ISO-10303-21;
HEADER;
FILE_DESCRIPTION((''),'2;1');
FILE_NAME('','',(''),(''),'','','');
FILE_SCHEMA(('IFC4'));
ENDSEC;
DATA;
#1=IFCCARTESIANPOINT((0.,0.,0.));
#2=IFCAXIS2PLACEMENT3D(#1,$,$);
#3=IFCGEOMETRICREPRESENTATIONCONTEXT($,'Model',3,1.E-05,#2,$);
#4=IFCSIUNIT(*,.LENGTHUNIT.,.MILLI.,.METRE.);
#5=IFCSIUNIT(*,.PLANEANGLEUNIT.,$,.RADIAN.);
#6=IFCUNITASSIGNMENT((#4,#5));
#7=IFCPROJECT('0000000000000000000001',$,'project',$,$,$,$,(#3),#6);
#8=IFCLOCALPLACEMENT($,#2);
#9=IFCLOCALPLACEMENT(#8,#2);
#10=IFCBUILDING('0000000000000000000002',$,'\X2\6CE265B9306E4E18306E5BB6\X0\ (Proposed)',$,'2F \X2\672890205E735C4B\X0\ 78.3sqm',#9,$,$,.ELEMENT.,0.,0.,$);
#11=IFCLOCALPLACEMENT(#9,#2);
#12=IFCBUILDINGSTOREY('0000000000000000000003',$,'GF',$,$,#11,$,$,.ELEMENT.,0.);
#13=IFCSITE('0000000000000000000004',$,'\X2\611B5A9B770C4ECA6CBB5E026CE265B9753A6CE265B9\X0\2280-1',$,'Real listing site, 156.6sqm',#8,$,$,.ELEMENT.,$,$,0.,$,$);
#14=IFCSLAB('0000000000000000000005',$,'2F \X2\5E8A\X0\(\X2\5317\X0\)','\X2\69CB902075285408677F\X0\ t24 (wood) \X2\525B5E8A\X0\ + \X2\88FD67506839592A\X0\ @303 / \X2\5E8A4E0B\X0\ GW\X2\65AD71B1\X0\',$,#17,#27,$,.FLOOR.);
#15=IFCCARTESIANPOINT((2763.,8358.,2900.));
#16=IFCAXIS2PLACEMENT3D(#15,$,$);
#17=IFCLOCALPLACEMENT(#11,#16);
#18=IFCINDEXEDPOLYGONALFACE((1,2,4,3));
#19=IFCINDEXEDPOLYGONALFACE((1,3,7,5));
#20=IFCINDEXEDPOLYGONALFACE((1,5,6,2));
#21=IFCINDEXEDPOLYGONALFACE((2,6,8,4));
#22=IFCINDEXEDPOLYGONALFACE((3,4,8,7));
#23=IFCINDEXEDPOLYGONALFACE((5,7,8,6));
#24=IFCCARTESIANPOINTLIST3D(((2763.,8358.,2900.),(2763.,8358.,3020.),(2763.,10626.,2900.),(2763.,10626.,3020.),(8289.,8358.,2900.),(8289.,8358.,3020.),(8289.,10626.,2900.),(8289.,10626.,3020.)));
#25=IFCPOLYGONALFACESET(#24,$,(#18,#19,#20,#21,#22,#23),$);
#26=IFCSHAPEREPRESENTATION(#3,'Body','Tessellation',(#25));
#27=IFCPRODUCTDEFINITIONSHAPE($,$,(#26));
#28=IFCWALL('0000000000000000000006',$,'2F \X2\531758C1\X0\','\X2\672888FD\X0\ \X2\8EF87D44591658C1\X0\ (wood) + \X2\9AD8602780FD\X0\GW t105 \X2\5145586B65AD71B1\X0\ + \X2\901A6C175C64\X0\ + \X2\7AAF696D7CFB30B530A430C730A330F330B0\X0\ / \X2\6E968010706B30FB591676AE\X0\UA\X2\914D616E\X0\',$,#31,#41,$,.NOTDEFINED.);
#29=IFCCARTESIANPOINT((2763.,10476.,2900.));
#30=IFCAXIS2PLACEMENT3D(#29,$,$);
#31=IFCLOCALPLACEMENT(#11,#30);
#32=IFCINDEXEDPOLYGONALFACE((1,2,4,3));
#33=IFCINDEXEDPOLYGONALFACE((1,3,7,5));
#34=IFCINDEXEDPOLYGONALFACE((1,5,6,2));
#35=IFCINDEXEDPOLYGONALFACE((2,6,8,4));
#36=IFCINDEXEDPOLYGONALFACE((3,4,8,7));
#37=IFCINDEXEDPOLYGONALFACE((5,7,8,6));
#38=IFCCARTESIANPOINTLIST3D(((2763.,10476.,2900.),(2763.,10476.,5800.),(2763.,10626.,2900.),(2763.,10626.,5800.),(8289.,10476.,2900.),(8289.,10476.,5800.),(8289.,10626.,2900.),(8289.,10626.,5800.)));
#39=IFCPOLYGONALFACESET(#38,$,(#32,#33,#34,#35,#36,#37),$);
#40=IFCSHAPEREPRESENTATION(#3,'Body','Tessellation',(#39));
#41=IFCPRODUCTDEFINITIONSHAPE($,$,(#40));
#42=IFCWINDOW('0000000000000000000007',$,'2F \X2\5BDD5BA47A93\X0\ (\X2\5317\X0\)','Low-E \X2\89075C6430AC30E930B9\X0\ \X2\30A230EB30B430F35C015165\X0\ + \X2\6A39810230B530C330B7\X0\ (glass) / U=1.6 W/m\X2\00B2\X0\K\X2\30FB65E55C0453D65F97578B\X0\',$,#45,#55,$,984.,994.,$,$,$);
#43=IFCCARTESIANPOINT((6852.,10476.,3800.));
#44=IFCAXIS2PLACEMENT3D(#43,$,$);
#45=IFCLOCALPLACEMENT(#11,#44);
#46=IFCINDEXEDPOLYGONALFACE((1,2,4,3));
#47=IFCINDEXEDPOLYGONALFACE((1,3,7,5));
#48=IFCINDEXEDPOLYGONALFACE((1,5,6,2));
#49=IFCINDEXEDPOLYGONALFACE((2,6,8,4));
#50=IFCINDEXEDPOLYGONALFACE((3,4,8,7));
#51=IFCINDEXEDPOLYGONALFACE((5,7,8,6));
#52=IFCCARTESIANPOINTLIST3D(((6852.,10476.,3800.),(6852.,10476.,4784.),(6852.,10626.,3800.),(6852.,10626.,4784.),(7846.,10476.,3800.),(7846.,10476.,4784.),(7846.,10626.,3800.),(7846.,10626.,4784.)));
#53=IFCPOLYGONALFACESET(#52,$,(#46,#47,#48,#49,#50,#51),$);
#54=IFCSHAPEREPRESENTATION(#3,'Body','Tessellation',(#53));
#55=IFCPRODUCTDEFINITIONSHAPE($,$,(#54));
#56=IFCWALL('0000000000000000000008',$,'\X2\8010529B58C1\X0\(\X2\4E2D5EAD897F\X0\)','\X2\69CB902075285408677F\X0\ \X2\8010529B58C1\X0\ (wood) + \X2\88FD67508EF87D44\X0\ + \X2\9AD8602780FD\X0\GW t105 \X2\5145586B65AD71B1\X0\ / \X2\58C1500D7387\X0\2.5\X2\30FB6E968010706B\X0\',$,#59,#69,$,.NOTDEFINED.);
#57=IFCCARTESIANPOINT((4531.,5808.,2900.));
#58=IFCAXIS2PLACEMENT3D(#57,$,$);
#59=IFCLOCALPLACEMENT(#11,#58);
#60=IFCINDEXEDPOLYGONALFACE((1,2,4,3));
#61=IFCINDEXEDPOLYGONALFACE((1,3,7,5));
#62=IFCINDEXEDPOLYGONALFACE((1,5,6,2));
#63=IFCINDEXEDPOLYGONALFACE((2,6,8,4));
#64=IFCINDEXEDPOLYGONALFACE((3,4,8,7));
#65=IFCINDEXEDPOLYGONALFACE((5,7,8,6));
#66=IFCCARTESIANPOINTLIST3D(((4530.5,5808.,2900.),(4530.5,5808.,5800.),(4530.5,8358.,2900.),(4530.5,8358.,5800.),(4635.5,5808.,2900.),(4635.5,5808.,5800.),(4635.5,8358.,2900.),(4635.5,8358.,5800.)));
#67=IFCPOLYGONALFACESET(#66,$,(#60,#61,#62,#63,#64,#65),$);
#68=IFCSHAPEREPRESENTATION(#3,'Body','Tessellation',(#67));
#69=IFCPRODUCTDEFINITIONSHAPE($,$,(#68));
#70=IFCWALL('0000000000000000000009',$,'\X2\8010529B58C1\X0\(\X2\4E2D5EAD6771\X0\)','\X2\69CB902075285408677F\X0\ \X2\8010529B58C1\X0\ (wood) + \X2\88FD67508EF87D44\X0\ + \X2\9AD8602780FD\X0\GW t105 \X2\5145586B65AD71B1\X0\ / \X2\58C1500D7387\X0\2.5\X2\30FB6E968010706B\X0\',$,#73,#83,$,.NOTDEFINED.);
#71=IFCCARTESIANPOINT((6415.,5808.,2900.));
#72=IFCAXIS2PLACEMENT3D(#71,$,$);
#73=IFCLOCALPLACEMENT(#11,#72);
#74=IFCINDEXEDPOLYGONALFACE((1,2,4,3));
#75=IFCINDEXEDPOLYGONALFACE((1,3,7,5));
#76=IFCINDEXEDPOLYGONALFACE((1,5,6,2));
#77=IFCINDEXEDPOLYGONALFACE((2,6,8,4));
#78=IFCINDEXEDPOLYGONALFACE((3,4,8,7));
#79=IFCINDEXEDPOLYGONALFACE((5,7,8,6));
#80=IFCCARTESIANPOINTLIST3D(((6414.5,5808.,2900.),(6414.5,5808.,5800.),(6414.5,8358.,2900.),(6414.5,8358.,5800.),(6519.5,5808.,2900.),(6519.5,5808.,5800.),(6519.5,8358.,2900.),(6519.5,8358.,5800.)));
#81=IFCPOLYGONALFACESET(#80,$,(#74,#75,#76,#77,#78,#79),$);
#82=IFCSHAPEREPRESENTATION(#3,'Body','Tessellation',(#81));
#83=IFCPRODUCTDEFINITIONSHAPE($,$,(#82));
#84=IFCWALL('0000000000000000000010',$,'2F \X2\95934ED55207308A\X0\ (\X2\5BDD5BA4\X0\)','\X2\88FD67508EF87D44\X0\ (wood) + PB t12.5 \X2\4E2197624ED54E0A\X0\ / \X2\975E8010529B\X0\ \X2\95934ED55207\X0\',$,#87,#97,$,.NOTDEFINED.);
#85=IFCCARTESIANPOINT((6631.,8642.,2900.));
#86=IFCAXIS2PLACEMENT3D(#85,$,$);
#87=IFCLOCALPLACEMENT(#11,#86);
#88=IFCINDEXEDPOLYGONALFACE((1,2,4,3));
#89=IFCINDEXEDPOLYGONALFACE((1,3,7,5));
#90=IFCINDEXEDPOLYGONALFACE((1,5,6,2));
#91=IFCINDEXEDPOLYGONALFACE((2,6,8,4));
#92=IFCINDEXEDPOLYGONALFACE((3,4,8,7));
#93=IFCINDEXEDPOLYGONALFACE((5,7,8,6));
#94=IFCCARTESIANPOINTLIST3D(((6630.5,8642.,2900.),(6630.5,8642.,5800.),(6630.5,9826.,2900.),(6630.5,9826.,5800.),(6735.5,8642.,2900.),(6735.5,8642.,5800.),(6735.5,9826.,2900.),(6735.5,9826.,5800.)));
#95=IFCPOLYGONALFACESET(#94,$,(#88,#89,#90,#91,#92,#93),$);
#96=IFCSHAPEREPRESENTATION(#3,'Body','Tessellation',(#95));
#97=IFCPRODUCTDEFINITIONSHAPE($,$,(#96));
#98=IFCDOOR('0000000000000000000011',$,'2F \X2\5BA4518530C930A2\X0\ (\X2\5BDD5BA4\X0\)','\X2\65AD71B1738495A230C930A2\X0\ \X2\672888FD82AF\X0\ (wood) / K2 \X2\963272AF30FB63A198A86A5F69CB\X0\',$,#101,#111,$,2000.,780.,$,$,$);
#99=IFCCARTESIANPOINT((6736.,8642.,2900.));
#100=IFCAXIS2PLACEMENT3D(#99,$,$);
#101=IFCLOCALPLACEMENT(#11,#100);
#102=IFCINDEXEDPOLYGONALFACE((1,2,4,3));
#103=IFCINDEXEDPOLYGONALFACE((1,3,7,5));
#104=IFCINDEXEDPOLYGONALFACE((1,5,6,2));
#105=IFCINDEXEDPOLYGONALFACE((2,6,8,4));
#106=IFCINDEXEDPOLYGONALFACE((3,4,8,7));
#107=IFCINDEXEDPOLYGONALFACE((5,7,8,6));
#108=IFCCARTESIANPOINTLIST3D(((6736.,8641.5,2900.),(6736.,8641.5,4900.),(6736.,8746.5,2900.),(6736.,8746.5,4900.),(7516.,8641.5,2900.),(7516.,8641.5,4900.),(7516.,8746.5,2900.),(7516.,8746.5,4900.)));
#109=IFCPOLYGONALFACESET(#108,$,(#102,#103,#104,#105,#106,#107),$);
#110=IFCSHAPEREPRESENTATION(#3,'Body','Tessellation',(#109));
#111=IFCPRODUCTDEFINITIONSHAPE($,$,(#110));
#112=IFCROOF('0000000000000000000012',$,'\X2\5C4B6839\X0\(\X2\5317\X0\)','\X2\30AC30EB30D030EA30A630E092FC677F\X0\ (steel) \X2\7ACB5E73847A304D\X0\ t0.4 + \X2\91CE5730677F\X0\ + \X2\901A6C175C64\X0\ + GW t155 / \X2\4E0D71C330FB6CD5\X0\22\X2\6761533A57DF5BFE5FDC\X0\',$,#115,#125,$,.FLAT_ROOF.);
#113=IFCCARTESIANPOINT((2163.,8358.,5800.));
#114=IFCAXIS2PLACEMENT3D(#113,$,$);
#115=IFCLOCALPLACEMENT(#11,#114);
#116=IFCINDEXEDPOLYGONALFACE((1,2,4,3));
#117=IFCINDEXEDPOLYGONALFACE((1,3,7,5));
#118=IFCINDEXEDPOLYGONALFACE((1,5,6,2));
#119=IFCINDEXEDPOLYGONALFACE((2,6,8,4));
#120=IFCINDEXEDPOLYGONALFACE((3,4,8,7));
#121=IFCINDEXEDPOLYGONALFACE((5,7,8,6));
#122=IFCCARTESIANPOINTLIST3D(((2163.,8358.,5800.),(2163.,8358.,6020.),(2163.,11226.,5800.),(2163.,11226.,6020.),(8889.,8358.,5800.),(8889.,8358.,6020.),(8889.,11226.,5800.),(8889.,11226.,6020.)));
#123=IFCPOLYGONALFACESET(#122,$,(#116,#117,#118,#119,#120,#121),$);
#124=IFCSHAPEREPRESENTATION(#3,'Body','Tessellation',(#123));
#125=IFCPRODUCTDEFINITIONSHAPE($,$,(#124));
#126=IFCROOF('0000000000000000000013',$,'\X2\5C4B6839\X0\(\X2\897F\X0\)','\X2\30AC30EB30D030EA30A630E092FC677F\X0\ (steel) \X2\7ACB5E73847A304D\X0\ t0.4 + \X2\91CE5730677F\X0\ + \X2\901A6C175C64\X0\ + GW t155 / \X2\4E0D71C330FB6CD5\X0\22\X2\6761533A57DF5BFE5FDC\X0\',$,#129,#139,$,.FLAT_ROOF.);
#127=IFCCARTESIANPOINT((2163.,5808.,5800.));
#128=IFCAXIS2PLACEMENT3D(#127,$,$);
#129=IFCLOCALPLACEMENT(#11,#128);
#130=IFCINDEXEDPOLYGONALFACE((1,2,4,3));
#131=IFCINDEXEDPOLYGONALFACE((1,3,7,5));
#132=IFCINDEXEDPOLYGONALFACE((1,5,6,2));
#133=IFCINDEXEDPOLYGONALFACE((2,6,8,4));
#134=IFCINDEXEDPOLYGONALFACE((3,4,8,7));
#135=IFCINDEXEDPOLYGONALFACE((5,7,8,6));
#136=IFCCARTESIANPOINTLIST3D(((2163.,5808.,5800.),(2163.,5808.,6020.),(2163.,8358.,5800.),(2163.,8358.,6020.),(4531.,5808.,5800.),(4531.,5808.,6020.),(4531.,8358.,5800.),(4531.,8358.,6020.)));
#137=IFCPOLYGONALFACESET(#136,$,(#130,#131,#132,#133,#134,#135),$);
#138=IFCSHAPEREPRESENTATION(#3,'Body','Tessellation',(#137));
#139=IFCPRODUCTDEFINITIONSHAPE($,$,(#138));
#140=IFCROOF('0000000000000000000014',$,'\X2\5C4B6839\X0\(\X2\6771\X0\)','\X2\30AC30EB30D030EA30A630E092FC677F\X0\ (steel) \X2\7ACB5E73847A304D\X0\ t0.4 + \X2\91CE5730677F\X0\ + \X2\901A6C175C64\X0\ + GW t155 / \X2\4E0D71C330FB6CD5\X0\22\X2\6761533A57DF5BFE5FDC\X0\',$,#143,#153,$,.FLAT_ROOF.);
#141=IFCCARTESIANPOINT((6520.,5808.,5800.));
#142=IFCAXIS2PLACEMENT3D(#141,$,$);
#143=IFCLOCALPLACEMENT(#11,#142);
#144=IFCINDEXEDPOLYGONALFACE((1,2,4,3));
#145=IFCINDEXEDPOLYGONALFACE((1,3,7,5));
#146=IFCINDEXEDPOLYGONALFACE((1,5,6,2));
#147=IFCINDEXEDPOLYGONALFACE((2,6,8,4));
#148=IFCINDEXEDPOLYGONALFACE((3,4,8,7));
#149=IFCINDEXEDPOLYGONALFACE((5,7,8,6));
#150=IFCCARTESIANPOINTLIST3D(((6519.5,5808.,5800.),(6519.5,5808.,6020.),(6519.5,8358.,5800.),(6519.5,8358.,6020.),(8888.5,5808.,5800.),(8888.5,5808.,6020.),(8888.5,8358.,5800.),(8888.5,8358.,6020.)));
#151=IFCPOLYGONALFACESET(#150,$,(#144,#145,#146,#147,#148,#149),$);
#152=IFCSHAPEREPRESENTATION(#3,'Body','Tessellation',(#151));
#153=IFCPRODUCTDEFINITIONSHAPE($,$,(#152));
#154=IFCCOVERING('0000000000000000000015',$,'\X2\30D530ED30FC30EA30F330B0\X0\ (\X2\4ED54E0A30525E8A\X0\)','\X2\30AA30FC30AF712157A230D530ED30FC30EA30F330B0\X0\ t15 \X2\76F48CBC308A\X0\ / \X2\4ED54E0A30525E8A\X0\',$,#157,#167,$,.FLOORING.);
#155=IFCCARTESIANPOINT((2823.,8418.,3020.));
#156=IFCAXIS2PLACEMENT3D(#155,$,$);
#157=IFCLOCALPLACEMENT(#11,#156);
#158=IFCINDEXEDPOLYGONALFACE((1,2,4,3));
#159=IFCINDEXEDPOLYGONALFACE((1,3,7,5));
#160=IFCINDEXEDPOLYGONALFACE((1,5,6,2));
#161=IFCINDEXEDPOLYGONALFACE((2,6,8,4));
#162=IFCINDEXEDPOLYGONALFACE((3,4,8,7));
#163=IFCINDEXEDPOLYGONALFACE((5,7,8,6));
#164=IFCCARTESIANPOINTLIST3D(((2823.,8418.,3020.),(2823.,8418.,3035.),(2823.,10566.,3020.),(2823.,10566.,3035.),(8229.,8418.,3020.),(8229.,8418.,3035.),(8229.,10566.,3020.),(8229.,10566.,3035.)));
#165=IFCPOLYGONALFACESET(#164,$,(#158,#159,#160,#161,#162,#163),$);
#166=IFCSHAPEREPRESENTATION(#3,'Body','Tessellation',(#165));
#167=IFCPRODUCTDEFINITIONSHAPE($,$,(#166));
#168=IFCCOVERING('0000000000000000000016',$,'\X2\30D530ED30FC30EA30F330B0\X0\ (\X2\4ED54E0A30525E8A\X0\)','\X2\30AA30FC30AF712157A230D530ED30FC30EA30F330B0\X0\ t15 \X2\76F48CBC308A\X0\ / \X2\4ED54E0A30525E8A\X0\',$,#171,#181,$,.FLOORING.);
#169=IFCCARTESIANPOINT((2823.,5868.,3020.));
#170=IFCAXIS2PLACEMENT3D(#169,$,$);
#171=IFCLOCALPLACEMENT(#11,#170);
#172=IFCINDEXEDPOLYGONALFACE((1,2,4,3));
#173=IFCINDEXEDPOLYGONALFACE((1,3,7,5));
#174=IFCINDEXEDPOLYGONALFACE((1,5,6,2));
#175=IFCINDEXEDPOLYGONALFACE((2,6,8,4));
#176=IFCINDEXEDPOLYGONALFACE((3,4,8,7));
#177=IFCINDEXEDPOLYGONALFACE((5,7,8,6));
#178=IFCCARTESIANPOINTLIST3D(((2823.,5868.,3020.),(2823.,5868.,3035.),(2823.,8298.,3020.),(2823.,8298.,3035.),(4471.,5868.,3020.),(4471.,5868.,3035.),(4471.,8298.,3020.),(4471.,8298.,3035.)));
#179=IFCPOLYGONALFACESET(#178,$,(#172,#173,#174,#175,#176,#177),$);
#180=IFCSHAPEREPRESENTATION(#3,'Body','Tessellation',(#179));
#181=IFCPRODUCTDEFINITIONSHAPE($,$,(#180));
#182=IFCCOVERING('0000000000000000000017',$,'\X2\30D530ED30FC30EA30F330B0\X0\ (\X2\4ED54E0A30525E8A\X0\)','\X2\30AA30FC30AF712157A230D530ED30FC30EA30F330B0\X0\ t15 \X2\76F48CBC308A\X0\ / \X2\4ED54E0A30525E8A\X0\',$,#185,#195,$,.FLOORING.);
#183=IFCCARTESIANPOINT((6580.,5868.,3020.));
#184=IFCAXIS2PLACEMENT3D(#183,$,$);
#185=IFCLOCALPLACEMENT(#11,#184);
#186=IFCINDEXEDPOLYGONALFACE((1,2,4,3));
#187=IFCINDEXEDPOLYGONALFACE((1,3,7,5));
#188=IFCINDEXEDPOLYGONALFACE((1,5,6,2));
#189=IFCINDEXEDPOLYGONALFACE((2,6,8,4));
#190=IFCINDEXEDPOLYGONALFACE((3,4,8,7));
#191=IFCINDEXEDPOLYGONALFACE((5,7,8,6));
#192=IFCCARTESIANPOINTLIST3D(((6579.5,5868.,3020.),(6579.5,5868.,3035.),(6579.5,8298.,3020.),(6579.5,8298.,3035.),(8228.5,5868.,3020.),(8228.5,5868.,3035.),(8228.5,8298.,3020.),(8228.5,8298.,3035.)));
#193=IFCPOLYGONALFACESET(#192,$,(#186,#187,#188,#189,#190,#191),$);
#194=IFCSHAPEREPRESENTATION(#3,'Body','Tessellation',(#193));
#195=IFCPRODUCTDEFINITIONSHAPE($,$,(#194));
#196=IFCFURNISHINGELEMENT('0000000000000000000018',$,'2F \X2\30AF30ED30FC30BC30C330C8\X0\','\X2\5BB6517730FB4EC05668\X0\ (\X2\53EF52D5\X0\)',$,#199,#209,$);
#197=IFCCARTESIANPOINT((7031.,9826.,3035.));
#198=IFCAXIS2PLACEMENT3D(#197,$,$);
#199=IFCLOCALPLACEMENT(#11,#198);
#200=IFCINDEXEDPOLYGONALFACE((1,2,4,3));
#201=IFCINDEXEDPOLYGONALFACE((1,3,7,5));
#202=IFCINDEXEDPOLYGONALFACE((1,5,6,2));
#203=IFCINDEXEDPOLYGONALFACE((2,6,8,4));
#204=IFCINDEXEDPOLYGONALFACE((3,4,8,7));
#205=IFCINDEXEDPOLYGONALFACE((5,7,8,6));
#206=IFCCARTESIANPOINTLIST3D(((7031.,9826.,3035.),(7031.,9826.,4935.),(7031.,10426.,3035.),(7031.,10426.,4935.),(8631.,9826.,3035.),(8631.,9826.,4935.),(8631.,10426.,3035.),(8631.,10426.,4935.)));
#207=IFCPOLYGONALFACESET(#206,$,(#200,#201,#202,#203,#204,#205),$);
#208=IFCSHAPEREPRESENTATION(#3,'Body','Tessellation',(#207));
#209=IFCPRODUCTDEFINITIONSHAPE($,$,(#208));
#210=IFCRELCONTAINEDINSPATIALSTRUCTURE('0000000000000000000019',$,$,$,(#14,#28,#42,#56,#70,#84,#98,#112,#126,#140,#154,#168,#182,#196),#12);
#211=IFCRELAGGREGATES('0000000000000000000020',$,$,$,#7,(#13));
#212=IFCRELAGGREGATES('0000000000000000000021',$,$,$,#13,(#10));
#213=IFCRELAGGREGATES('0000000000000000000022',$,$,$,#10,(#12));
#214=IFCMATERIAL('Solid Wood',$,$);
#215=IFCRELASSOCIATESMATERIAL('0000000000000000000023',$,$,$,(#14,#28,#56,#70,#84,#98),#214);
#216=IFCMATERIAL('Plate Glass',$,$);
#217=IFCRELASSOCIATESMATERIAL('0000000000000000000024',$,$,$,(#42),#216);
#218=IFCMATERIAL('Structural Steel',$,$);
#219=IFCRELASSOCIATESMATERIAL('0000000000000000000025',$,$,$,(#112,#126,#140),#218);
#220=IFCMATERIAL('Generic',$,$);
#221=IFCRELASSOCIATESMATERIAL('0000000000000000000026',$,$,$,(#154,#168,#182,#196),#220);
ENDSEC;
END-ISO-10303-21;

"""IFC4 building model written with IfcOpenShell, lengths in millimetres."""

from ifc_helpers import new_model, si_unit, frame, frame_2d, origin, place, context, project, spatial, rectangle, extrude, material, element, fill, save


model = new_model("IFC4")

# Units and contexts
model_context = context("Model", 3, precision=1e-05, world=origin())
ifc_project = project(units=[si_unit("LENGTHUNIT", "METRE", prefix="MILLI"), si_unit("PLANEANGLEUNIT", "RADIAN")], contexts=[model_context])

# Site, building, storey
site_placement = place(None, origin())
site = spatial("IfcSite", under=ifc_project, at=site_placement, Name="愛媛県今治市波方町波方2280-1", ObjectType="Real listing site, 156.6sqm", CompositionType="ELEMENT", RefElevation=0.0)
building_placement = place(site_placement, origin())
building = spatial("IfcBuilding", under=site, at=building_placement, Name="波方の丘の家 (Proposed)", ObjectType="2F 木造平屋 78.3sqm", CompositionType="ELEMENT", ElevationOfRefHeight=0.0, ElevationOfTerrain=0.0)
storey_placement = place(building_placement, origin())
storey = spatial("IfcBuildingStorey", under=building, at=storey_placement, Name="GF", CompositionType="ELEMENT", Elevation=0.0)

# Slab
ifc_material_1 = material(Name="Solid Wood")
slab_placement = place(storey_placement, frame((2763.0, 8358.0, 2900.0)))
element("IfcSlab", 1, at=slab_placement, inside=storey, material=ifc_material_1, Name="2F 床(北)", Description="構造用合板 t24 (wood) 剛床 + 製材根太 @303 / 床下 GW断熱", PredefinedType="FLOOR", context=model_context, shape_type="SweptSolid", body=[
    extrude(rectangle(XDim=5526.0, YDim=2268.0, at=frame_2d((2763.0, 1134.0))), frame((2763.0, 8358.0, 2900.0)), (0.0, 0.0, 1.0), 120.0),
])

# Wall, opening, window
wall_1_placement = place(storey_placement, frame((2763.0, 10476.0, 2900.0)))
wall_1 = element("IfcWall", 2, at=wall_1_placement, inside=storey, material=ifc_material_1, Name="2F 北壁", Description="木製 軸組外壁 (wood) + 高性能GW t105 充填断熱 + 通気層 + 窯業系サイディング / 準耐火・外皮UA配慮", PredefinedType="NOTDEFINED", context=model_context, shape_type="SweptSolid", body=[
    extrude(rectangle(XDim=5526.0, YDim=150.0, at=frame_2d((2763.0, 75.0))), frame((2763.0, 10476.0, 2900.0)), (0.0, 0.0, 1.0), 2900.0),
])
opening_1_placement = place(storey_placement, frame((6852.0, 10476.0, 3800.0)))
opening_1 = element("IfcOpeningElement", 3, at=opening_1_placement, cuts=wall_1, PredefinedType="NOTDEFINED", context=model_context, shape_type="SweptSolid", body=[
    extrude(rectangle(XDim=994.0, YDim=150.0, at=frame_2d((497.0, 75.0))), frame((6852.0, 10476.0, 3800.0)), (0.0, 0.0, 1.0), 984.0),
])
ifc_material_2 = material(Name="Plate Glass")
window_1_placement = place(storey_placement, frame((6852.0, 10476.0, 3800.0)))
window_1 = element("IfcWindow", 4, at=window_1_placement, inside=storey, material=ifc_material_2, Name="2F 寝室窓 (北)", Description="Low-E 複層ガラス アルゴン封入 + 樹脂サッシ (glass) / U=1.6 W/m²K・日射取得型", OverallHeight=984.0, OverallWidth=994.0, context=model_context, shape_type="SweptSolid", body=[
    extrude(rectangle(XDim=994.0, YDim=150.0, at=frame_2d((497.0, 75.0))), frame((6852.0, 10476.0, 3800.0)), (0.0, 0.0, 1.0), 984.0),
])
fill(opening_1, window_1)

# Walls
wall_2_placement = place(storey_placement, frame((4531.0, 5808.0, 2900.0)))
element("IfcWall", 5, at=wall_2_placement, inside=storey, material=ifc_material_1, Name="耐力壁(中庭西)", Description="構造用合板 耐力壁 (wood) + 製材軸組 + 高性能GW t105 充填断熱 / 壁倍率2.5・準耐火", PredefinedType="NOTDEFINED", context=model_context, shape_type="SweptSolid", body=[
    extrude(rectangle(XDim=105.0, YDim=2550.0, at=frame_2d((52.0, 1275.0))), frame((4531.0, 5808.0, 2900.0)), (0.0, 0.0, 1.0), 2900.0),
])
wall_3_placement = place(storey_placement, frame((6415.0, 5808.0, 2900.0)))
element("IfcWall", 6, at=wall_3_placement, inside=storey, material=ifc_material_1, Name="耐力壁(中庭東)", Description="構造用合板 耐力壁 (wood) + 製材軸組 + 高性能GW t105 充填断熱 / 壁倍率2.5・準耐火", PredefinedType="NOTDEFINED", context=model_context, shape_type="SweptSolid", body=[
    extrude(rectangle(XDim=105.0, YDim=2550.0, at=frame_2d((52.0, 1275.0))), frame((6415.0, 5808.0, 2900.0)), (0.0, 0.0, 1.0), 2900.0),
])
wall_4_placement = place(storey_placement, frame((6631.0, 8642.0, 2900.0)))
element("IfcWall", 7, at=wall_4_placement, inside=storey, material=ifc_material_1, Name="2F 間仕切り (寝室)", Description="製材軸組 (wood) + PB t12.5 両面仕上 / 非耐力 間仕切", PredefinedType="NOTDEFINED", context=model_context, shape_type="SweptSolid", body=[
    extrude(rectangle(XDim=105.0, YDim=1184.0, at=frame_2d((52.0, 592.0))), frame((6631.0, 8642.0, 2900.0)), (0.0, 0.0, 1.0), 2900.0),
])

# Door
door_placement = place(storey_placement, frame((6736.0, 8642.0, 2900.0)))
element("IfcDoor", 8, at=door_placement, inside=storey, material=ifc_material_1, Name="2F 室内ドア (寝室)", Description="断熱玄関ドア 木製芯 (wood) / K2 防犯・採風機構", OverallHeight=2000.0, OverallWidth=780.0, context=model_context, shape_type="SweptSolid", body=[
    extrude(rectangle(XDim=780.0, YDim=105.0, at=frame_2d((390.0, 52.0))), frame((6736.0, 8642.0, 2900.0)), (0.0, 0.0, 1.0), 2000.0),
])

# Roofs
ifc_material_3 = material(Name="Structural Steel")
for number, where, name in (
    (9, (2163.0, 8358.0, 5800.0), "屋根(北)"),
):
    element("IfcRoof", number, at=place(storey_placement, frame(where)), inside=storey, material=ifc_material_3, Name=name, Description="ガルバリウム鋼板 (steel) 立平葺き t0.4 + 野地板 + 通気層 + GW t155 / 不燃・法22条区域対応", PredefinedType="FLAT_ROOF", context=model_context, shape_type="SweptSolid", body=[
        extrude(rectangle(XDim=6726.0, YDim=2868.0, at=frame_2d((3363.0, 1434.0))), frame((2163.0, 8358.0, 5800.0)), (0.0, 0.0, 1.0), 220.0),
    ])
roof_1_placement = place(storey_placement, frame((2163.0, 5808.0, 5800.0)))
element("IfcRoof", 10, at=roof_1_placement, inside=storey, material=ifc_material_3, Name="屋根(西)", Description="ガルバリウム鋼板 (steel) 立平葺き t0.4 + 野地板 + 通気層 + GW t155 / 不燃・法22条区域対応", PredefinedType="FLAT_ROOF", context=model_context, shape_type="SweptSolid", body=[
    extrude(rectangle(XDim=2368.0, YDim=2550.0, at=frame_2d((1184.0, 1275.0))), frame((2163.0, 5808.0, 5800.0)), (0.0, 0.0, 1.0), 220.0),
])
roof_2_placement = place(storey_placement, frame((6520.0, 5808.0, 5800.0)))
element("IfcRoof", 11, at=roof_2_placement, inside=storey, material=ifc_material_3, Name="屋根(東)", Description="ガルバリウム鋼板 (steel) 立平葺き t0.4 + 野地板 + 通気層 + GW t155 / 不燃・法22条区域対応", PredefinedType="FLAT_ROOF", context=model_context, shape_type="SweptSolid", body=[
    extrude(rectangle(XDim=2369.0, YDim=2550.0, at=frame_2d((1184.0, 1275.0))), frame((6520.0, 5808.0, 5800.0)), (0.0, 0.0, 1.0), 220.0),
])

# Coverings
ifc_material_4 = material(Name="Generic")
covering_1_placement = place(storey_placement, frame((2823.0, 8418.0, 3020.0)))
element("IfcCovering", 12, at=covering_1_placement, inside=storey, material=ifc_material_4, Name="フローリング (仕上げ床)", Description="オーク無垢フローリング t15 直貼り / 仕上げ床", PredefinedType="FLOORING", context=model_context, shape_type="SweptSolid", body=[
    extrude(rectangle(XDim=5406.0, YDim=2148.0, at=frame_2d((2703.0, 1074.0))), frame((2823.0, 8418.0, 3020.0)), (0.0, 0.0, 1.0), 15.0),
])
covering_2_placement = place(storey_placement, frame((2823.0, 5868.0, 3020.0)))
element("IfcCovering", 13, at=covering_2_placement, inside=storey, material=ifc_material_4, Name="フローリング (仕上げ床)", Description="オーク無垢フローリング t15 直貼り / 仕上げ床", PredefinedType="FLOORING", context=model_context, shape_type="SweptSolid", body=[
    extrude(rectangle(XDim=1648.0, YDim=2430.0, at=frame_2d((824.0, 1215.0))), frame((2823.0, 5868.0, 3020.0)), (0.0, 0.0, 1.0), 15.0),
])
covering_3_placement = place(storey_placement, frame((6580.0, 5868.0, 3020.0)))
element("IfcCovering", 14, at=covering_3_placement, inside=storey, material=ifc_material_4, Name="フローリング (仕上げ床)", Description="オーク無垢フローリング t15 直貼り / 仕上げ床", PredefinedType="FLOORING", context=model_context, shape_type="SweptSolid", body=[
    extrude(rectangle(XDim=1649.0, YDim=2430.0, at=frame_2d((824.0, 1215.0))), frame((6580.0, 5868.0, 3020.0)), (0.0, 0.0, 1.0), 15.0),
])

# Furnishing element
furnishing_1_placement = place(storey_placement, frame((7031.0, 9826.0, 3035.0)))
element("IfcFurnishingElement", 15, at=furnishing_1_placement, inside=storey, material=ifc_material_4, Name="2F クローゼット", Description="家具・什器 (可動)", context=model_context, shape_type="SweptSolid", body=[
    extrude(rectangle(XDim=1600.0, YDim=600.0, at=frame_2d((800.0, 300.0))), frame((7031.0, 9826.0, 3035.0)), (0.0, 0.0, 1.0), 1900.0),
])

save(model, "model.ifc")
